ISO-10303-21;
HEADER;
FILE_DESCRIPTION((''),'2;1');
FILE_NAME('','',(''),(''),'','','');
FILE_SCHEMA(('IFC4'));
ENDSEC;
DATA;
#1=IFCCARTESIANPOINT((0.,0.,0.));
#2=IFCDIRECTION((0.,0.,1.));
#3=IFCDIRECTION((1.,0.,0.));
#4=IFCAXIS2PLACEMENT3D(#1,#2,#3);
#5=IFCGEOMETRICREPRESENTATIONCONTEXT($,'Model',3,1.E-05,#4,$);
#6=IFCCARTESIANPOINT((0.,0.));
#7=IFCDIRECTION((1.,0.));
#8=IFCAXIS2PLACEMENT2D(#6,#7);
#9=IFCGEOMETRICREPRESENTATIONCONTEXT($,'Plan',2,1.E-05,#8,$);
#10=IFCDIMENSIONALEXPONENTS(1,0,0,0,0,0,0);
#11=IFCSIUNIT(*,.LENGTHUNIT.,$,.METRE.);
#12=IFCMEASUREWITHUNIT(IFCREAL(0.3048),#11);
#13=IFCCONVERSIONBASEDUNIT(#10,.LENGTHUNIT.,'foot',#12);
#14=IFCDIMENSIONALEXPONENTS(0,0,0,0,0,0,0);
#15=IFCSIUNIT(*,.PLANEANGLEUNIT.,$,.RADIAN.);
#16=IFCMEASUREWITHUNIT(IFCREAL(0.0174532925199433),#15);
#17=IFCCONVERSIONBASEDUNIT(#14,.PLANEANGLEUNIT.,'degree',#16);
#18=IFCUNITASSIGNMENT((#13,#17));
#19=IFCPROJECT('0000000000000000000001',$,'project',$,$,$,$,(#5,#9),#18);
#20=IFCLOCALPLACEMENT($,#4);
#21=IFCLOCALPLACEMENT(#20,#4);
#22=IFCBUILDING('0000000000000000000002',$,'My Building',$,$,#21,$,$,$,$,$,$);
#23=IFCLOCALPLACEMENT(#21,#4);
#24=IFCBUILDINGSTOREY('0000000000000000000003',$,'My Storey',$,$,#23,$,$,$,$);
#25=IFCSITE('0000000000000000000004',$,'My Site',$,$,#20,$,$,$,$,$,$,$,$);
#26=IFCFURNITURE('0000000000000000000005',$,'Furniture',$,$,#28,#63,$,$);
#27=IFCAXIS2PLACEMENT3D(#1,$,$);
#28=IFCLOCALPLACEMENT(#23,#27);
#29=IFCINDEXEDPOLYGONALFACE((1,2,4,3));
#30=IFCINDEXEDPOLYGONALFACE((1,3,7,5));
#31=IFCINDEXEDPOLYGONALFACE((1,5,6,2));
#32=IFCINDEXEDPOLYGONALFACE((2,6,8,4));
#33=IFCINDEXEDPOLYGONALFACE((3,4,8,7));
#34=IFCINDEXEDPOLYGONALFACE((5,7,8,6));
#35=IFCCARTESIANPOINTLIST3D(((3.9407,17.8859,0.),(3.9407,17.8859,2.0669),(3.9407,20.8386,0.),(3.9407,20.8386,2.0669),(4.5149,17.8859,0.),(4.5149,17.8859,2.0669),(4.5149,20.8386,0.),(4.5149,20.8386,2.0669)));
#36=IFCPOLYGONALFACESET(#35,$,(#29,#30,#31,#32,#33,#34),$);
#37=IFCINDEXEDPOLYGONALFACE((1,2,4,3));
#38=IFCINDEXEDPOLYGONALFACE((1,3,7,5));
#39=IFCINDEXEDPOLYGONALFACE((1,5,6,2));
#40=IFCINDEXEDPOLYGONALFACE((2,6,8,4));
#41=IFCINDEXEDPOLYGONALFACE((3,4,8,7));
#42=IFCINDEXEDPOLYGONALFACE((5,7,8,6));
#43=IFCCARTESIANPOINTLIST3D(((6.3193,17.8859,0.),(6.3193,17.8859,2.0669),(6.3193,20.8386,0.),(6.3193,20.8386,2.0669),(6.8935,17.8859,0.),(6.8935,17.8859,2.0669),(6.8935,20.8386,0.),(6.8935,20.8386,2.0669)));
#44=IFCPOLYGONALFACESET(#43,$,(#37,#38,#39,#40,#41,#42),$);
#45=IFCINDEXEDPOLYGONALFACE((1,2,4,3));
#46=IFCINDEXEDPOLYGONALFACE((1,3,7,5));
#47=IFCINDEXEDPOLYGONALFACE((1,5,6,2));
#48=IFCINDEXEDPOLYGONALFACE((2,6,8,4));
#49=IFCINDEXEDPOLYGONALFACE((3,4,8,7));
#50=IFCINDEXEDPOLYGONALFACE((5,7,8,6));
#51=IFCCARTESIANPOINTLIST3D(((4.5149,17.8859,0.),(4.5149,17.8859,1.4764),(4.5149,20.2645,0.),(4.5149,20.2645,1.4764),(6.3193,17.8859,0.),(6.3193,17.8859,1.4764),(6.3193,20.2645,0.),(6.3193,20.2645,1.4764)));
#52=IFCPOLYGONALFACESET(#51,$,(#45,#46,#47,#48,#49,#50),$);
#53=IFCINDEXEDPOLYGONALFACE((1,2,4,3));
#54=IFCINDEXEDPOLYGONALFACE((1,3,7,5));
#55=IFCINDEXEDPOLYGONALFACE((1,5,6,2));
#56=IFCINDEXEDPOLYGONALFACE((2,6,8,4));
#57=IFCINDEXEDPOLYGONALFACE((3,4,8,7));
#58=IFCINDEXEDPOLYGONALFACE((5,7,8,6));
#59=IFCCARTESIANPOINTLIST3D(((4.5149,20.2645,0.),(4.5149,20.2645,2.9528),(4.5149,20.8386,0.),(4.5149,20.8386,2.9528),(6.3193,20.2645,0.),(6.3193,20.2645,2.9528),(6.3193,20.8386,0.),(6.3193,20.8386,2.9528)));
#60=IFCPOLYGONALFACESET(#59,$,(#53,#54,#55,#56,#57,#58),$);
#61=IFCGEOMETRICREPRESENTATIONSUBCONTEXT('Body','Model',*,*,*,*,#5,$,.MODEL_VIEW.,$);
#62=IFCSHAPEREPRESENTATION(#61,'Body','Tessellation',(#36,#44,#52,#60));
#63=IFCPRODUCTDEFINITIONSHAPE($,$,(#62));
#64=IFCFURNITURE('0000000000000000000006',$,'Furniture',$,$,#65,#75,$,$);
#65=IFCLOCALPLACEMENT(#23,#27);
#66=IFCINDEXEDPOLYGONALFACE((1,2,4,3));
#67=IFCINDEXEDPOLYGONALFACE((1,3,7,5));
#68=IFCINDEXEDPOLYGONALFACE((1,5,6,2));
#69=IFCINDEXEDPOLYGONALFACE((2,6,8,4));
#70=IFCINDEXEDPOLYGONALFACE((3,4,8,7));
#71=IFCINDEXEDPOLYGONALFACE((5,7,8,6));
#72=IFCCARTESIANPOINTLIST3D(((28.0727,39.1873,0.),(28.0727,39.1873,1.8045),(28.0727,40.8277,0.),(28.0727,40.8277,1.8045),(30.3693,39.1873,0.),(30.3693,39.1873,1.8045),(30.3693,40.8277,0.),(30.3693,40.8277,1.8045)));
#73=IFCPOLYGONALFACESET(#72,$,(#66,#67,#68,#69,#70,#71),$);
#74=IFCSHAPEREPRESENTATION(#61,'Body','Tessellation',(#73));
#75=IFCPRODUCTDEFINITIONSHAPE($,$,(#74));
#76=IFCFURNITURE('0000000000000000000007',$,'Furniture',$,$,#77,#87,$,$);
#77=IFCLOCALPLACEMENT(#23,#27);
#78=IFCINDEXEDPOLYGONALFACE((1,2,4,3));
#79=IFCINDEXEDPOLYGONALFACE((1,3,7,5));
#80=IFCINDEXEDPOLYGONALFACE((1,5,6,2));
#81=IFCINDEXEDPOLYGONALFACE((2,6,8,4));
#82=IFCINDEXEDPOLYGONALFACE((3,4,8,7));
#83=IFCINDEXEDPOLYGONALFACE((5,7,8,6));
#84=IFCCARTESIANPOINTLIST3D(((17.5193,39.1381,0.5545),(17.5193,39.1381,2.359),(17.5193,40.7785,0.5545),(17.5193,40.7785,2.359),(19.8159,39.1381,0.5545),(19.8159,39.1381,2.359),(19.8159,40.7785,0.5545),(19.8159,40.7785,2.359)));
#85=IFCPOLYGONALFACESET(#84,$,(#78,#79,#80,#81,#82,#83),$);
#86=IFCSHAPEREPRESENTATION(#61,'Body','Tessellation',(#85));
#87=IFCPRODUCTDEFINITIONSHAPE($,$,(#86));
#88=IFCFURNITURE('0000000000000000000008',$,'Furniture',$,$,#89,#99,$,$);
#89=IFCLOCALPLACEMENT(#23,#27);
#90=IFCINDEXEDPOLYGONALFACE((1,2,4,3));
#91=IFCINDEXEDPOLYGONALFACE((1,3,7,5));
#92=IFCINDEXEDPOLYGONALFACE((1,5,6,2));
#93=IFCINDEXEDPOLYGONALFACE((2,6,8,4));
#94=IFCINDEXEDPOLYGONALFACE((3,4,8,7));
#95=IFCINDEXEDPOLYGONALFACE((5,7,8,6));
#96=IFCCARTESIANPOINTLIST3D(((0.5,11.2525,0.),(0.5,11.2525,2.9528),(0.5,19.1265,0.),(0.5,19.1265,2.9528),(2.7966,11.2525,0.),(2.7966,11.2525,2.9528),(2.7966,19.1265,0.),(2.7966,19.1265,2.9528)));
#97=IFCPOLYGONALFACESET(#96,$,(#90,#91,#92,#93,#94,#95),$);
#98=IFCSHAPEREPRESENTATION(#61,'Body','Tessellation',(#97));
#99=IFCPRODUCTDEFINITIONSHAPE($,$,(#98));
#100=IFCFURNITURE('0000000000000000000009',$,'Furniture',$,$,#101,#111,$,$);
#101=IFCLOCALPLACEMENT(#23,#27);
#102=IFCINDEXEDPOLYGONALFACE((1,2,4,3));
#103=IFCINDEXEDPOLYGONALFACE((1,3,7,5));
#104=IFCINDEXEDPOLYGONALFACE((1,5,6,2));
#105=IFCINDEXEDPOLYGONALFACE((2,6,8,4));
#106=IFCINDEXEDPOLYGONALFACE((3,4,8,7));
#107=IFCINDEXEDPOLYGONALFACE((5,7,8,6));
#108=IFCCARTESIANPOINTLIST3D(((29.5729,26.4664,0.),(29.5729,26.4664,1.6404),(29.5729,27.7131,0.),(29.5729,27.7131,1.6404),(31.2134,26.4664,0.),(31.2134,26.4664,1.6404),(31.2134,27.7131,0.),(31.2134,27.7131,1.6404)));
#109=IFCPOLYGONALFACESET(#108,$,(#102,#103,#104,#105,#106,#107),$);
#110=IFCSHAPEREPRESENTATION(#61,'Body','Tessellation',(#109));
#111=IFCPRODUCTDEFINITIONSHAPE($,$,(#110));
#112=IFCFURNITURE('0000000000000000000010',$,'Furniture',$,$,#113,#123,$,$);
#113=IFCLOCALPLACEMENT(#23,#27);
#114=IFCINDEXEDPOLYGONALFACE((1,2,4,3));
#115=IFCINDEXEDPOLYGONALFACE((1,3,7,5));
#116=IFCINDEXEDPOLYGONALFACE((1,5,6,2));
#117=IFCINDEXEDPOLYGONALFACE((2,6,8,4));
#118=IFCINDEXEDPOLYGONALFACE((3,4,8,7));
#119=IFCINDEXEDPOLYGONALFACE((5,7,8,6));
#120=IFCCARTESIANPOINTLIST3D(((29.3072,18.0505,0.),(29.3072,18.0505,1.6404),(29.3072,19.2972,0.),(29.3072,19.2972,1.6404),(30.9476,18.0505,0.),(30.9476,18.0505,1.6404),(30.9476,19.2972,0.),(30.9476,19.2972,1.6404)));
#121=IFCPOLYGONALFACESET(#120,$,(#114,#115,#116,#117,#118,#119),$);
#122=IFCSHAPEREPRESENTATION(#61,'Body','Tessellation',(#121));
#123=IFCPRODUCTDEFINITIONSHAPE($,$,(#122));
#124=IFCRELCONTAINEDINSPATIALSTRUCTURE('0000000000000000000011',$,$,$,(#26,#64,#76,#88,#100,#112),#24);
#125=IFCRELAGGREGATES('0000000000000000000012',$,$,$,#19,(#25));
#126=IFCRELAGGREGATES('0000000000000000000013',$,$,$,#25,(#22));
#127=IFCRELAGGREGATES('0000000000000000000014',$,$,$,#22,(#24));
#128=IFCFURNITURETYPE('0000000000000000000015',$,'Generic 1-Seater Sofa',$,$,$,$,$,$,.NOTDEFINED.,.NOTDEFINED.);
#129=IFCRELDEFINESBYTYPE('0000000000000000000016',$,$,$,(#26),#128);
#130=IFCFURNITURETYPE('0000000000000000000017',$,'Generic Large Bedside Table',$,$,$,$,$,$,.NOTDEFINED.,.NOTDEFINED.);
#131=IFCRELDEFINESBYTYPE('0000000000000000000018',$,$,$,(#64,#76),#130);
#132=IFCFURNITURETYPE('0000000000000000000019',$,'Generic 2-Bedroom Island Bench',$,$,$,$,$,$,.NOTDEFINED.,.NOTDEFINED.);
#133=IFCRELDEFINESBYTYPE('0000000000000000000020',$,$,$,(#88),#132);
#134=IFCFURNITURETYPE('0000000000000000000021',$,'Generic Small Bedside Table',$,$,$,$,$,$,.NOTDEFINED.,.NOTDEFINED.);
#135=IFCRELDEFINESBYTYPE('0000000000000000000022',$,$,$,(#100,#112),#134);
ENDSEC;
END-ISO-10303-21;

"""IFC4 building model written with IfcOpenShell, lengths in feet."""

from ifc_helpers import new_model, entity, si_unit, converted_unit, frame, origin_with_axes, origin_2d_with_axis, place, context, subcontext, project, spatial, line, indexed_curve, outline, extrude, shape, source, transform, mapped, type_object, type_shapes, element, save


model = new_model("IFC4")

# Units and contexts
model_context = context("Model", 3, precision=1e-05, world=origin_with_axes())
plan_context = context("Plan", 2, precision=1e-05, world=origin_2d_with_axis())
body_context_1 = subcontext(model_context, "Body", "Model", "MODEL_VIEW")
body_context_2 = subcontext(plan_context, "Body", "Plan", "PLAN_VIEW")
ifc_project = project(units=[converted_unit("LENGTHUNIT", "foot", entity("IfcReal", 0.3048), si_unit("LENGTHUNIT", "METRE"), dimensions=[1, 0, 0, 0, 0, 0, 0]), converted_unit("PLANEANGLEUNIT", "degree", entity("IfcReal", 0.0174532925199433), si_unit("PLANEANGLEUNIT", "RADIAN"), dimensions=[0, 0, 0, 0, 0, 0, 0])], contexts=[model_context, plan_context])

# Site, building, storey
site_placement = place(None, origin_with_axes())
site = spatial("IfcSite", under=ifc_project, at=site_placement, Name="My Site")
building_placement = place(site_placement, origin_with_axes())
building = spatial("IfcBuilding", under=site, at=building_placement, Name="My Building")
storey_placement = place(building_placement, origin_with_axes())
storey = spatial("IfcBuildingStorey", under=building, at=storey_placement, Name="My Storey")

# Furniture
furniture_type_1 = type_object("IfcFurnitureType", Name="Generic 1-Seater Sofa", AssemblyPlace="NOTDEFINED", PredefinedType="NOTDEFINED")
shared_shape_1 = source(origin_with_axes(), body_context_1, "Body", "SweptSolid", [
    extrude(outline(indexed_curve([(0.0, 0.0), (0.5741, 0.0), (0.5741, 2.9528), (0.0, 2.9528)], segments=[line(1, 2, 3, 4, 1)])), frame((-1.4764, -2.9528, 0.0), z_axis=(0.0, 0.0, 1.0), x_axis=(1.0, 0.0, 0.0)), (0.0, 0.0, 1.0), 2.0669),
    extrude(outline(indexed_curve([(0.0, 0.0), (0.5741, 0.0), (0.5741, 2.9528), (0.0, 2.9528)], segments=[line(1, 2, 3, 4, 1)])), frame((0.9022, -2.9528, 0.0), z_axis=(0.0, 0.0, 1.0), x_axis=(1.0, 0.0, 0.0)), (0.0, 0.0, 1.0), 2.0669),
    extrude(outline(indexed_curve([(0.5741, 0.0), (2.3786, 0.0), (2.3786, 2.3786), (0.5741, 2.3786)], segments=[line(1, 2, 3, 4, 1)])), frame((-1.4764, -2.9528, 0.0), z_axis=(0.0, 0.0, 1.0), x_axis=(1.0, 0.0, 0.0)), (0.0, 0.0, 1.0), 1.4764),
    extrude(outline(indexed_curve([(0.5741, 2.3786), (2.3786, 2.3786), (2.3786, 2.9528), (0.5741, 2.9528)], segments=[line(1, 2, 3, 4, 1)])), frame((-1.4764, -2.9528, 0.0), z_axis=(0.0, 0.0, 1.0), x_axis=(1.0, 0.0, 0.0)), (0.0, 0.0, 1.0), 2.9528),
])
shared_shape_2 = source(origin_with_axes(), body_context_2, "Body", "Curve2D", [
    entity("IfcIndexedPolyCurve", entity("IfcCartesianPointList2D", [[-1.4764, -2.9528], [-0.9022, -2.9528], [-0.9022, 0.0], [-1.4764, 0.0]]), [entity("IfcLineIndex", [1, 2, 3, 4, 1])]),
    entity("IfcIndexedPolyCurve", entity("IfcCartesianPointList2D", [[0.9022, -2.9528], [1.4764, -2.9528], [1.4764, 0.0], [0.9022, 0.0]]), [entity("IfcLineIndex", [1, 2, 3, 4, 1])]),
    entity("IfcIndexedPolyCurve", entity("IfcCartesianPointList2D", [[-0.9022, -2.9528], [0.9022, -2.9528], [0.9022, -0.5741], [-0.9022, -0.5741]]), [entity("IfcLineIndex", [1, 2, 3, 4, 1])]),
    entity("IfcIndexedPolyCurve", entity("IfcCartesianPointList2D", [[-0.9022, -0.5741], [0.9022, -0.5741], [0.9022, 0.0], [-0.9022, 0.0]]), [entity("IfcLineIndex", [1, 2, 3, 4, 1])]),
])
type_shapes(furniture_type_1, [shared_shape_1, shared_shape_2])
furniture_1_placement = place(storey_placement, frame((5.4171, 20.8386, 0.0), z_axis=(0.0, 0.0, 1.0), x_axis=(1.0, 0.0, 0.0)))
element("IfcFurniture", 1, at=furniture_1_placement, inside=storey, type_object=furniture_type_1, Name="Furniture", shapes=[
    shape(body_context_1, "Body", "MappedRepresentation", [mapped(shared_shape_1, transform((0.0, 0.0, 0.0), x_axis=(1.0, 0.0, 0.0), y_axis=(0.0, 1.0, 0.0), z_axis=(0.0, 0.0, 1.0), scale=1.0))]),
    shape(body_context_2, "Body", "MappedRepresentation", [mapped(shared_shape_2, transform((0.0, 0.0, 0.0), x_axis=(1.0, 0.0, 0.0), y_axis=(0.0, 1.0, 0.0), z_axis=(0.0, 0.0, 1.0), scale=1.0))]),
])
furniture_type_2 = type_object("IfcFurnitureType", Name="Generic Large Bedside Table", AssemblyPlace="NOTDEFINED", PredefinedType="NOTDEFINED")
shared_shape_3 = source(origin_with_axes(), body_context_1, "Body", "SweptSolid", [
    extrude(outline(indexed_curve([(0.0, 0.0), (2.2966, 0.0), (2.2966, 1.6404), (0.0, 1.6404)], segments=[line(1, 2, 3, 4, 1)])), frame((-1.1483, -0.8202, 0.0), z_axis=(0.0, 0.0, 1.0), x_axis=(1.0, 0.0, 0.0)), (0.0, 0.0, 1.0), 1.8045),
])
shared_shape_4 = source(origin_with_axes(), body_context_2, "Body", "Curve2D", [
    entity("IfcIndexedPolyCurve", entity("IfcCartesianPointList2D", [[-1.1483, -0.8202], [1.1483, -0.8202], [1.1483, 0.8202], [-1.1483, 0.8202]]), [entity("IfcLineIndex", [1, 2, 3, 4, 1])]),
])
type_shapes(furniture_type_2, [shared_shape_3, shared_shape_4])
for number, where, z_axis, x_axis, name in (
    (2, (29.221, 40.0075, 0.0), (0.0, 0.0, 1.0), (1.0, 0.0, 0.0), "Furniture"),
    (3, (18.6676, 39.9583, 0.5545), (0.0, 0.0, 1.0), (1.0, 0.0, 0.0), "Furniture"),
):
    element("IfcFurniture", number, at=place(storey_placement, frame(where, z_axis=z_axis, x_axis=x_axis)), inside=storey, type_object=furniture_type_2, Name=name, shapes=[
        shape(body_context_1, "Body", "MappedRepresentation", [mapped(shared_shape_3, transform((0.0, 0.0, 0.0), x_axis=(1.0, 0.0, 0.0), y_axis=(0.0, 1.0, 0.0), z_axis=(0.0, 0.0, 1.0), scale=1.0))]),
        shape(body_context_2, "Body", "MappedRepresentation", [mapped(shared_shape_4, transform((0.0, 0.0, 0.0), x_axis=(1.0, 0.0, 0.0), y_axis=(0.0, 1.0, 0.0), z_axis=(0.0, 0.0, 1.0), scale=1.0))]),
    ])
furniture_type_3 = type_object("IfcFurnitureType", Name="Generic 2-Bedroom Island Bench", AssemblyPlace="NOTDEFINED", PredefinedType="NOTDEFINED")
shared_shape_5 = source(origin_with_axes(), body_context_1, "Body", "SweptSolid", [
    extrude(outline(indexed_curve([(0.0, 0.0), (7.874, 0.0), (7.874, 2.2966), (0.0, 2.2966)], segments=[line(1, 2, 3, 4, 1)])), origin_with_axes(), (0.0, 0.0, 1.0), 2.9528),
])
shared_shape_6 = source(origin_with_axes(), body_context_2, "Body", "Curve2D", [
    entity("IfcIndexedPolyCurve", entity("IfcCartesianPointList2D", [[0.0, 0.0], [7.874, 0.0], [7.874, 2.2966], [0.0, 2.2966]]), [entity("IfcLineIndex", [1, 2, 3, 4, 1])]),
])
type_shapes(furniture_type_3, [shared_shape_5, shared_shape_6])
furniture_2_placement = place(storey_placement, frame((0.5, 19.1265, 0.0), z_axis=(0.0, 0.0, 1.0), x_axis=(0.0, -1.0, 0.0)))
element("IfcFurniture", 4, at=furniture_2_placement, inside=storey, type_object=furniture_type_3, Name="Furniture", shapes=[
    shape(body_context_1, "Body", "MappedRepresentation", [mapped(shared_shape_5, transform((0.0, 0.0, 0.0), x_axis=(1.0, 0.0, 0.0), y_axis=(0.0, 1.0, 0.0), z_axis=(0.0, 0.0, 1.0), scale=1.0))]),
    shape(body_context_2, "Body", "MappedRepresentation", [mapped(shared_shape_6, transform((0.0, 0.0, 0.0), x_axis=(1.0, 0.0, 0.0), y_axis=(0.0, 1.0, 0.0), z_axis=(0.0, 0.0, 1.0), scale=1.0))]),
])
furniture_type_4 = type_object("IfcFurnitureType", Name="Generic Small Bedside Table", AssemblyPlace="NOTDEFINED", PredefinedType="NOTDEFINED")
shared_shape_7 = source(origin_with_axes(), body_context_1, "Body", "SweptSolid", [
    extrude(outline(indexed_curve([(0.0, 0.0), (1.6404, 0.0), (1.6404, 1.2467), (0.0, 1.2467)], segments=[line(1, 2, 3, 4, 1)])), frame((-0.8202, -0.6234, 0.0), z_axis=(0.0, 0.0, 1.0), x_axis=(1.0, 0.0, 0.0)), (0.0, 0.0, 1.0), 1.6404),
])
shared_shape_8 = source(origin_with_axes(), body_context_2, "Body", "Curve2D", [
    entity("IfcIndexedPolyCurve", entity("IfcCartesianPointList2D", [[-0.8202, -0.6234], [0.8202, -0.6234], [0.8202, 0.6234], [-0.8202, 0.6234]]), [entity("IfcLineIndex", [1, 2, 3, 4, 1])]),
])
type_shapes(furniture_type_4, [shared_shape_7, shared_shape_8])
for number, where, z_axis, x_axis, name in (
    (5, (30.3932, 27.0898, 0.0), (0.0, 0.0, 1.0), (1.0, 0.0, 0.0), "Furniture"),
    (6, (30.1274, 18.6739, 0.0), (0.0, 0.0, 1.0), (1.0, 0.0, 0.0), "Furniture"),
):
    element("IfcFurniture", number, at=place(storey_placement, frame(where, z_axis=z_axis, x_axis=x_axis)), inside=storey, type_object=furniture_type_4, Name=name, shapes=[
        shape(body_context_1, "Body", "MappedRepresentation", [mapped(shared_shape_7, transform((0.0, 0.0, 0.0), x_axis=(1.0, 0.0, 0.0), y_axis=(0.0, 1.0, 0.0), z_axis=(0.0, 0.0, 1.0), scale=1.0))]),
        shape(body_context_2, "Body", "MappedRepresentation", [mapped(shared_shape_8, transform((0.0, 0.0, 0.0), x_axis=(1.0, 0.0, 0.0), y_axis=(0.0, 1.0, 0.0), z_axis=(0.0, 0.0, 1.0), scale=1.0))]),
    ])

save(model, "model.ifc")
